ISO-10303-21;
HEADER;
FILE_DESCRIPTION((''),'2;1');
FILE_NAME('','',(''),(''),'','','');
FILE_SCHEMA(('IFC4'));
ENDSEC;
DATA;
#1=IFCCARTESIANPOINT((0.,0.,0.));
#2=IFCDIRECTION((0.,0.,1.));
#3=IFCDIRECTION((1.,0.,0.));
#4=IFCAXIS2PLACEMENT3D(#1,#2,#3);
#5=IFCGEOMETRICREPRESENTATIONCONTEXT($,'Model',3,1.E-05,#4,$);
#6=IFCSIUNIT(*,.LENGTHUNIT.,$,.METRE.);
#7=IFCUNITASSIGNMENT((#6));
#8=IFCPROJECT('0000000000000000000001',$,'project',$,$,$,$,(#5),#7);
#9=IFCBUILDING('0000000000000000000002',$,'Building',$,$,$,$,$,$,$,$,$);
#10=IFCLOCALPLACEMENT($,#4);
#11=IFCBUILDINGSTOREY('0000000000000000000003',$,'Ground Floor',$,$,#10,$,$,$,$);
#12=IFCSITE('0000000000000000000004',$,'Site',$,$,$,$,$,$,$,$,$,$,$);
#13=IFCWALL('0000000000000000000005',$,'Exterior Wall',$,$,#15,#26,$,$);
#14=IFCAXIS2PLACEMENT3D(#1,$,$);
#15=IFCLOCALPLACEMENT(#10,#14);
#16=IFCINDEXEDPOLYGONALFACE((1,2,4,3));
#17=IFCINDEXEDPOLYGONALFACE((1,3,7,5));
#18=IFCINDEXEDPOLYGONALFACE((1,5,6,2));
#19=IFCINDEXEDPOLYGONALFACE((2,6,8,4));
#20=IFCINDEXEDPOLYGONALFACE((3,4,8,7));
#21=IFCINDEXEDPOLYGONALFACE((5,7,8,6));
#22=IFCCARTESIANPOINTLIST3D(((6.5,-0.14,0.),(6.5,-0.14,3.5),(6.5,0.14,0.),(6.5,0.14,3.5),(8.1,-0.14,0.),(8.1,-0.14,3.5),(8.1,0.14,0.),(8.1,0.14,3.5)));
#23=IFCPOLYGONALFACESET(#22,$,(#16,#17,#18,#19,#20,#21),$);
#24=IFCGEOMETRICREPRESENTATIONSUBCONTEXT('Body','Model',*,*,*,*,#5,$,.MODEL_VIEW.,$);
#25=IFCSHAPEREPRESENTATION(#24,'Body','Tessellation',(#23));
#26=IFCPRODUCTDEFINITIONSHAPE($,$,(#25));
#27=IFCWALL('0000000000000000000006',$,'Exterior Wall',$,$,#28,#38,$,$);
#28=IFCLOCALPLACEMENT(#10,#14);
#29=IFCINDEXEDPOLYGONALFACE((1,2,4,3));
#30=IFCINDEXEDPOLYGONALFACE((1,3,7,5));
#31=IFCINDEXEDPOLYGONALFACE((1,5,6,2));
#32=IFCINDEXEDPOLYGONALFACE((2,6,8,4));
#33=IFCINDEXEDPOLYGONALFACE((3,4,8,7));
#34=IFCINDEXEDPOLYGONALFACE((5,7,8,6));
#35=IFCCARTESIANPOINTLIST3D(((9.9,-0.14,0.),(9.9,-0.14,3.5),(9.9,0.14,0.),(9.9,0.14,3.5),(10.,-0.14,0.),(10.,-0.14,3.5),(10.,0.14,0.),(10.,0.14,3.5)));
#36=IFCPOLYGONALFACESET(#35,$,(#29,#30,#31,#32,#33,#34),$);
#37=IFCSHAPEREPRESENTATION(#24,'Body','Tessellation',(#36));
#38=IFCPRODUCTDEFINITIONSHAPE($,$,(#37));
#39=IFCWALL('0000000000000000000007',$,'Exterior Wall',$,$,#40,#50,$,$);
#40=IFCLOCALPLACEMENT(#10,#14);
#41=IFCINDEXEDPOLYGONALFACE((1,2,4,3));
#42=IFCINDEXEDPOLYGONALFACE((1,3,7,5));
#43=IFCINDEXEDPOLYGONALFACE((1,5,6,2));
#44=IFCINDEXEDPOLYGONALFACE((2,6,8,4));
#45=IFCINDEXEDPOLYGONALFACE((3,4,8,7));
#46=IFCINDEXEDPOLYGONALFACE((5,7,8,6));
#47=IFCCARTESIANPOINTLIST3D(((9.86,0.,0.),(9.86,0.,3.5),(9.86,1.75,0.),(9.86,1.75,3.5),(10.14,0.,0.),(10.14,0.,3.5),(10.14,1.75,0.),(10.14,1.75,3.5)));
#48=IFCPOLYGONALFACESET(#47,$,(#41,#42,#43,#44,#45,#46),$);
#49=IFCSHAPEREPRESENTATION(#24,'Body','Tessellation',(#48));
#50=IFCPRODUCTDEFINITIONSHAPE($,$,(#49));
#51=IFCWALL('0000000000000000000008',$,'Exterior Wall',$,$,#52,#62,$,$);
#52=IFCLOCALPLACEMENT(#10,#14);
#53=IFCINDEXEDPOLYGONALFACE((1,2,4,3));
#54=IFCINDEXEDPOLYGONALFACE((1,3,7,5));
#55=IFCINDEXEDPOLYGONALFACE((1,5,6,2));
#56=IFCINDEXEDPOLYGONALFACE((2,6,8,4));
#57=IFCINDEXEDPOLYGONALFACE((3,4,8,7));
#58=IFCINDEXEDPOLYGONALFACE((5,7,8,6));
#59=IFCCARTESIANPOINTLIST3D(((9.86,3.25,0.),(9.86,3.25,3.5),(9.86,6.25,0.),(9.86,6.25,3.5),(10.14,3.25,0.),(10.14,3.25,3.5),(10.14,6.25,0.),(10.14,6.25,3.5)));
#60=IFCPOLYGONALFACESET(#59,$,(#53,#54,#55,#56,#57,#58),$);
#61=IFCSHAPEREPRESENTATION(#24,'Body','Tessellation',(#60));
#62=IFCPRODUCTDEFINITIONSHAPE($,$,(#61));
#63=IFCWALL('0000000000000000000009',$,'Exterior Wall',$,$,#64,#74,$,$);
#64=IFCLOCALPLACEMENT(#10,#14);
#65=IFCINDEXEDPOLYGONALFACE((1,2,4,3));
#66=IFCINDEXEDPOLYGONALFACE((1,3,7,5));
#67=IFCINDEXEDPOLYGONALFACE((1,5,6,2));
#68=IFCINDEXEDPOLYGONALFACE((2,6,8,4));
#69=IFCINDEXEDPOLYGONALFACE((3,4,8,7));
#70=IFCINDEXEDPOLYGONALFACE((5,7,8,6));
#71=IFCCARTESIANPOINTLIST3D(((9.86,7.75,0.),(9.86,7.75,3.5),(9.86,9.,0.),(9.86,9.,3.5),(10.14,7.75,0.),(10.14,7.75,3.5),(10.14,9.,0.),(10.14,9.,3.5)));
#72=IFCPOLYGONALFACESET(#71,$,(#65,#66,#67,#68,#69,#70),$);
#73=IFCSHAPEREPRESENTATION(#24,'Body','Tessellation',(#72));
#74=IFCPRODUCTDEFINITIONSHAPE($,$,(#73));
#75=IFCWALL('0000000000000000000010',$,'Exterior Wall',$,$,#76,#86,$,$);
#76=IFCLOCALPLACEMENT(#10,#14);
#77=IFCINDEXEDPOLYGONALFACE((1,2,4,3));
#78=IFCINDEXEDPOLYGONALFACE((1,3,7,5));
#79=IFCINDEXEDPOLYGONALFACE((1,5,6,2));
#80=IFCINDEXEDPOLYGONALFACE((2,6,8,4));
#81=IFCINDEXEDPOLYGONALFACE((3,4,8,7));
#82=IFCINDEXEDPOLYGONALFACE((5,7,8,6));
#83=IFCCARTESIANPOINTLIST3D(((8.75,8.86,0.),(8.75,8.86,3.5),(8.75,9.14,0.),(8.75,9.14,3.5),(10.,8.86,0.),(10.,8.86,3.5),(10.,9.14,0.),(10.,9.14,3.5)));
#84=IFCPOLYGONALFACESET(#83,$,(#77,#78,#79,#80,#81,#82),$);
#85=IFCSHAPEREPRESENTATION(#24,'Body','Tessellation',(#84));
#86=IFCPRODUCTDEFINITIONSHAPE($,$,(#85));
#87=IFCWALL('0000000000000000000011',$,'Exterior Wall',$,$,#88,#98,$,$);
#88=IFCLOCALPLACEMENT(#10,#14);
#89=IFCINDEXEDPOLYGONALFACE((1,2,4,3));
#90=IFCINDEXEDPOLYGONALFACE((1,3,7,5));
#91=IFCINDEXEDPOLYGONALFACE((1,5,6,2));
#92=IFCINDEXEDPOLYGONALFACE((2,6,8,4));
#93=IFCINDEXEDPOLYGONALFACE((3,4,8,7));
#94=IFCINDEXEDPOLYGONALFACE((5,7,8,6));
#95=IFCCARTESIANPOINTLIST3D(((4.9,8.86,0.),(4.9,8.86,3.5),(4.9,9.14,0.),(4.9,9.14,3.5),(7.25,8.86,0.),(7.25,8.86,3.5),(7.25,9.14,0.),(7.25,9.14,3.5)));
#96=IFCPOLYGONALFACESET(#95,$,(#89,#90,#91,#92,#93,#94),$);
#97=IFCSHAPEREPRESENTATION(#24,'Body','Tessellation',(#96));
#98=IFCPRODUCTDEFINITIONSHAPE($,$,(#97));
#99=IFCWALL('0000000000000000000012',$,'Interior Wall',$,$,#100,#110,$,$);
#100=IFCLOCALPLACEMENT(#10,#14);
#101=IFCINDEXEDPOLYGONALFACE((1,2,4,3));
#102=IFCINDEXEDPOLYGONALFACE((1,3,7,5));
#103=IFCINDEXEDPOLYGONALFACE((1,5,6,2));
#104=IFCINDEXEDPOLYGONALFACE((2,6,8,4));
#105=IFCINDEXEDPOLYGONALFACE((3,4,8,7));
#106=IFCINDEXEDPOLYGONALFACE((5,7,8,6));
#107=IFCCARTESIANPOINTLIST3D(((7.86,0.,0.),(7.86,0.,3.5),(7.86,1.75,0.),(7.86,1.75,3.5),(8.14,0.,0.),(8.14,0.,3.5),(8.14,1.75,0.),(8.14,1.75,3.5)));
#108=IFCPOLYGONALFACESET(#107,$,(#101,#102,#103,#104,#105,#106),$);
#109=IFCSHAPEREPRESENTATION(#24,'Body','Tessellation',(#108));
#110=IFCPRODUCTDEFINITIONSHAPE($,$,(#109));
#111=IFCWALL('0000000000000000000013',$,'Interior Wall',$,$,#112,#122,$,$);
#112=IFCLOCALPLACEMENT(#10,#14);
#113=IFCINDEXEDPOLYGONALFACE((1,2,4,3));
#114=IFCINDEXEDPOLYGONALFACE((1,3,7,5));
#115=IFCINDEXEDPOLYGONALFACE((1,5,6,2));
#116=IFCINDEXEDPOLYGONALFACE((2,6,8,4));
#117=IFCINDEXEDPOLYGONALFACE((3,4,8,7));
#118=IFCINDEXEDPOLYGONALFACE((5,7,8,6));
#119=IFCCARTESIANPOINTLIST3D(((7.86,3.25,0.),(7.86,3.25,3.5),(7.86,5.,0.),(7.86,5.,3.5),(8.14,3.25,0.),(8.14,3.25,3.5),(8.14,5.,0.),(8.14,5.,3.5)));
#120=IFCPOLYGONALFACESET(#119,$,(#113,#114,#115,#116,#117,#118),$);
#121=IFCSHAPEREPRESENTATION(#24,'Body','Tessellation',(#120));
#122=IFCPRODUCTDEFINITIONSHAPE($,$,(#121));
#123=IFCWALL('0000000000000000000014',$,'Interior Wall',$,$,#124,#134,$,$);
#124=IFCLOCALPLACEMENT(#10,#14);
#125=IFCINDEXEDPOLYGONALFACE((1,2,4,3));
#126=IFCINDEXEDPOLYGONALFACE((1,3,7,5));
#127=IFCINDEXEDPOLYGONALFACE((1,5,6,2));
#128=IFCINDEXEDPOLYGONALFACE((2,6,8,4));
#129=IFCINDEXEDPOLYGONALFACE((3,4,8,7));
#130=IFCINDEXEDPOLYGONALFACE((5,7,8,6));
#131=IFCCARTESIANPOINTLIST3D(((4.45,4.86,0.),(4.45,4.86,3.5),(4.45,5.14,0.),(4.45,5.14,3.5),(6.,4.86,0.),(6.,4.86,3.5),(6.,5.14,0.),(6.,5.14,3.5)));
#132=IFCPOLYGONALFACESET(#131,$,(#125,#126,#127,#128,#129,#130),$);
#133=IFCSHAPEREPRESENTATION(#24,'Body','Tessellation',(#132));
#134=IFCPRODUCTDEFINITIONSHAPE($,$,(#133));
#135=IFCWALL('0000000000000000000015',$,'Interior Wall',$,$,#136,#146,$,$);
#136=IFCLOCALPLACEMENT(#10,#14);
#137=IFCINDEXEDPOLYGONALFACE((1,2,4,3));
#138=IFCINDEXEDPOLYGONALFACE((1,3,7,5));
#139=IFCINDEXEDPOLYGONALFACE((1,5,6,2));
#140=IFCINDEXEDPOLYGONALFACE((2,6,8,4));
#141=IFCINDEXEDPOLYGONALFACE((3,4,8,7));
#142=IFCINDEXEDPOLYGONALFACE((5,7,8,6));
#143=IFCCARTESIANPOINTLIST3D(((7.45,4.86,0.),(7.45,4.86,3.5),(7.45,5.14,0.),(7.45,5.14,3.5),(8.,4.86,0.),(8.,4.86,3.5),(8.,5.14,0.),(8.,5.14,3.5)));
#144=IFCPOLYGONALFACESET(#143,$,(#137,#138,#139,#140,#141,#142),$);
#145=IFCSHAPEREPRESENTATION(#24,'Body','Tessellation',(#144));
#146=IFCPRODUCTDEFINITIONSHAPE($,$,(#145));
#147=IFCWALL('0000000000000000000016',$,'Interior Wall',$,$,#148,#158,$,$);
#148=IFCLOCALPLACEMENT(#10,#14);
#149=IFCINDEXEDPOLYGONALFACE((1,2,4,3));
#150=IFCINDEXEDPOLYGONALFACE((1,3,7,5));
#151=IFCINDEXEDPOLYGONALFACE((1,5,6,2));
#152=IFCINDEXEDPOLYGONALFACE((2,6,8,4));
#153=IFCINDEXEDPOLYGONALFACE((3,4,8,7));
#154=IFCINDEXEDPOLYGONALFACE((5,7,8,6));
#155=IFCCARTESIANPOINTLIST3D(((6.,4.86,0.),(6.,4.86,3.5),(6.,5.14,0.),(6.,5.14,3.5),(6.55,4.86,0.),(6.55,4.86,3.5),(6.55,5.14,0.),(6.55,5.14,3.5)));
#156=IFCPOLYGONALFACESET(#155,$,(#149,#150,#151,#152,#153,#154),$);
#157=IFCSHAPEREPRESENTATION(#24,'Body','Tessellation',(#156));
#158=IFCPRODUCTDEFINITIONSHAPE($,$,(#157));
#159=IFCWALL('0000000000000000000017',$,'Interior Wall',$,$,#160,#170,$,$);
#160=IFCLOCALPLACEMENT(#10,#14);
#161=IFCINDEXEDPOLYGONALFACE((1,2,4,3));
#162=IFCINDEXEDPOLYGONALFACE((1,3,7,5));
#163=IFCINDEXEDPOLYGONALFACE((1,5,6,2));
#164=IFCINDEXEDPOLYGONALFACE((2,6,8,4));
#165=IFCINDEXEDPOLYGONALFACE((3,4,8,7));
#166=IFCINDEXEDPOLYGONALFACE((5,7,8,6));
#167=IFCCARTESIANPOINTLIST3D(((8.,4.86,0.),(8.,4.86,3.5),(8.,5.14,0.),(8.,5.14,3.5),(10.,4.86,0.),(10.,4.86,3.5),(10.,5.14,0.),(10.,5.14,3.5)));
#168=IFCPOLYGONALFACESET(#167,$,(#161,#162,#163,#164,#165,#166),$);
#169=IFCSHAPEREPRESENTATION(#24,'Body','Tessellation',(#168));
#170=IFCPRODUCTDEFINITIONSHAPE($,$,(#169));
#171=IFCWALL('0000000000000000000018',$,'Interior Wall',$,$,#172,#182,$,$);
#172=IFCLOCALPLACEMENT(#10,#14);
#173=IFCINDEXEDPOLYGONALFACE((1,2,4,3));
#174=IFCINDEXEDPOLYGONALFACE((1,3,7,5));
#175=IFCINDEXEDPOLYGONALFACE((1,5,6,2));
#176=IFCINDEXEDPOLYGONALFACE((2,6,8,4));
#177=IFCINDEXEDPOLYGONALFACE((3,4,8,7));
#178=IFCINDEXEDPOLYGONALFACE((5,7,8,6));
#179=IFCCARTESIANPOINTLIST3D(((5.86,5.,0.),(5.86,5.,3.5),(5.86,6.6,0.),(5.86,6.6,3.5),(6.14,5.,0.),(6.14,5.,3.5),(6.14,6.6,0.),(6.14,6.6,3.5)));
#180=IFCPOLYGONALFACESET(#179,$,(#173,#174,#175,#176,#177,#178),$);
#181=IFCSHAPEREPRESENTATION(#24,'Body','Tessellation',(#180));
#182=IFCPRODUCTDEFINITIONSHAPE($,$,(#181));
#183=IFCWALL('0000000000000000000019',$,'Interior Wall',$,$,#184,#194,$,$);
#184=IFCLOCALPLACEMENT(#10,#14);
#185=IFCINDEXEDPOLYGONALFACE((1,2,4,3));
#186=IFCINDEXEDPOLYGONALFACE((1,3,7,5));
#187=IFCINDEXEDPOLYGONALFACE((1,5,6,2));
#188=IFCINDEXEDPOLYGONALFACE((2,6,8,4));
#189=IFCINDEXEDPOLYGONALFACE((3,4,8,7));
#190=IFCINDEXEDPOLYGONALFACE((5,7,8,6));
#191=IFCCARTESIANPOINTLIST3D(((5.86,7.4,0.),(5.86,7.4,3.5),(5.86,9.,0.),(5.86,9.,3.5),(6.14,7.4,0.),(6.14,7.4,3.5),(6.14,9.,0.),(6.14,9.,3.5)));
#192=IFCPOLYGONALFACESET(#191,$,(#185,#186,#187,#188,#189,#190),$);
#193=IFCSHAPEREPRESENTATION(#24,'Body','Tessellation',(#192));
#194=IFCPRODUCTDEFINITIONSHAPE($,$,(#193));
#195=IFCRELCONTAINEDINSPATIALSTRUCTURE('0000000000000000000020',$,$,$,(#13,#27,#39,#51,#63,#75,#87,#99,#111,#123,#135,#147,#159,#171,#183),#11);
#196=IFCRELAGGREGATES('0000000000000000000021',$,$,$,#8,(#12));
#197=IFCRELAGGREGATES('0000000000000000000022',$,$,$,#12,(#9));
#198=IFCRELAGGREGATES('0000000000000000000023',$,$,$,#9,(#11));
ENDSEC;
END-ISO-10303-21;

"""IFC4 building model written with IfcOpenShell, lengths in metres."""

from ifc_helpers import new_model, si_unit, frame, origin_with_axes, place, context, subcontext, project, spatial, indexed_curve, outline, extrude, element, save


model = new_model("IFC4")

# Units and contexts
model_context = context("Model", 3, precision=1e-05, world=origin_with_axes())
body_context = subcontext(model_context, "Body", "Model", "MODEL_VIEW")
ifc_project = project(units=[si_unit("LENGTHUNIT", "METRE")], contexts=[model_context])

# Site, building, storey
site = spatial("IfcSite", under=ifc_project, Name="Site")
building = spatial("IfcBuilding", under=site, Name="Building")
storey_placement = place(None, origin_with_axes())
storey = spatial("IfcBuildingStorey", under=building, at=storey_placement, Name="Ground Floor")

# Walls
wall_1_placement = place(storey_placement, frame((6.5, 0.0, 0.0), z_axis=(0.0, 0.0, 1.0), x_axis=(1.0, 0.0, 0.0)))
element("IfcWall", 1, at=wall_1_placement, inside=storey, Name="Exterior Wall", context=body_context, shape_type="SweptSolid", body=[
    extrude(outline(indexed_curve([(0.0, 0.0), (0.0, 0.28), (1.6, 0.28), (1.6, 0.0), (0.0, 0.0)], self_intersect=False)), frame((0.0, -0.14, 0.0), z_axis=(0.0, 0.0, 1.0), x_axis=(1.0, 0.0, 0.0)), (0.0, 0.0, 1.0), 3.5),
])
wall_2_placement = place(storey_placement, frame((9.9, 0.0, 0.0), z_axis=(0.0, 0.0, 1.0), x_axis=(1.0, 0.0, 0.0)))
element("IfcWall", 2, at=wall_2_placement, inside=storey, Name="Exterior Wall", context=body_context, shape_type="SweptSolid", body=[
    extrude(outline(indexed_curve([(0.0, 0.0), (0.0, 0.28), (0.1, 0.28), (0.1, 0.0), (0.0, 0.0)], self_intersect=False)), frame((0.0, -0.14, 0.0), z_axis=(0.0, 0.0, 1.0), x_axis=(1.0, 0.0, 0.0)), (0.0, 0.0, 1.0), 3.5),
])
wall_3_placement = place(storey_placement, frame((10.0, 0.0, 0.0), z_axis=(0.0, 0.0, 1.0), x_axis=(0.0, 1.0, 0.0)))
element("IfcWall", 3, at=wall_3_placement, inside=storey, Name="Exterior Wall", context=body_context, shape_type="SweptSolid", body=[
    extrude(outline(indexed_curve([(0.0, 0.0), (0.0, 0.28), (1.75, 0.28), (1.75, 0.0), (0.0, 0.0)], self_intersect=False)), frame((0.0, -0.14, 0.0), z_axis=(0.0, 0.0, 1.0), x_axis=(1.0, 0.0, 0.0)), (0.0, 0.0, 1.0), 3.5),
])
wall_4_placement = place(storey_placement, frame((10.0, 3.25, 0.0), z_axis=(0.0, 0.0, 1.0), x_axis=(0.0, 1.0, 0.0)))
element("IfcWall", 4, at=wall_4_placement, inside=storey, Name="Exterior Wall", context=body_context, shape_type="SweptSolid", body=[
    extrude(outline(indexed_curve([(0.0, 0.0), (0.0, 0.28), (3.0, 0.28), (3.0, 0.0), (0.0, 0.0)], self_intersect=False)), frame((0.0, -0.14, 0.0), z_axis=(0.0, 0.0, 1.0), x_axis=(1.0, 0.0, 0.0)), (0.0, 0.0, 1.0), 3.5),
])
for number, where, z_axis, x_axis, name in (
    (5, (10.0, 7.75, 0.0), (0.0, 0.0, 1.0), (0.0, 1.0, 0.0), "Exterior Wall"),
    (6, (10.0, 9.0, 0.0), (0.0, 0.0, 1.0), (-1.0, 0.0, 0.0), "Exterior Wall"),
):
    element("IfcWall", number, at=place(storey_placement, frame(where, z_axis=z_axis, x_axis=x_axis)), inside=storey, Name=name, context=body_context, shape_type="SweptSolid", body=[
        extrude(outline(indexed_curve([(0.0, 0.0), (0.0, 0.28), (1.25, 0.28), (1.25, 0.0), (0.0, 0.0)], self_intersect=False)), frame((0.0, -0.14, 0.0), z_axis=(0.0, 0.0, 1.0), x_axis=(1.0, 0.0, 0.0)), (0.0, 0.0, 1.0), 3.5),
    ])
wall_5_placement = place(storey_placement, frame((7.25, 9.0, 0.0), z_axis=(0.0, 0.0, 1.0), x_axis=(-1.0, 0.0, 0.0)))
element("IfcWall", 7, at=wall_5_placement, inside=storey, Name="Exterior Wall", context=body_context, shape_type="SweptSolid", body=[
    extrude(outline(indexed_curve([(0.0, 0.0), (0.0, 0.28), (2.35, 0.28), (2.35, 0.0), (0.0, 0.0)], self_intersect=False)), frame((0.0, -0.14, 0.0), z_axis=(0.0, 0.0, 1.0), x_axis=(1.0, 0.0, 0.0)), (0.0, 0.0, 1.0), 3.5),
])
for number, where, z_axis, x_axis, name in (
    (8, (8.0, 0.0, 0.0), (0.0, 0.0, 1.0), (0.0, 1.0, 0.0), "Interior Wall"),
    (9, (8.0, 3.25, 0.0), (0.0, 0.0, 1.0), (0.0, 1.0, 0.0), "Interior Wall"),
):
    element("IfcWall", number, at=place(storey_placement, frame(where, z_axis=z_axis, x_axis=x_axis)), inside=storey, Name=name, context=body_context, shape_type="SweptSolid", body=[
        extrude(outline(indexed_curve([(0.0, 0.0), (0.0, 0.28), (1.75, 0.28), (1.75, 0.0), (0.0, 0.0)], self_intersect=False)), frame((0.0, -0.14, 0.0), z_axis=(0.0, 0.0, 1.0), x_axis=(1.0, 0.0, 0.0)), (0.0, 0.0, 1.0), 3.5),
    ])
wall_6_placement = place(storey_placement, frame((6.0, 5.0, 0.0), z_axis=(0.0, 0.0, 1.0), x_axis=(-1.0, 0.0, 0.0)))
element("IfcWall", 10, at=wall_6_placement, inside=storey, Name="Interior Wall", context=body_context, shape_type="SweptSolid", body=[
    extrude(outline(indexed_curve([(0.0, 0.0), (0.0, 0.28), (1.55, 0.28), (1.55, 0.0), (0.0, 0.0)], self_intersect=False)), frame((0.0, -0.14, 0.0), z_axis=(0.0, 0.0, 1.0), x_axis=(1.0, 0.0, 0.0)), (0.0, 0.0, 1.0), 3.5),
])
for number, where, z_axis, x_axis, name in (
    (11, (8.0, 5.0, 0.0), (0.0, 0.0, 1.0), (-1.0, 0.0, 0.0), "Interior Wall"),
    (12, (6.55, 5.0, 0.0), (0.0, 0.0, 1.0), (-1.0, 0.0, 0.0), "Interior Wall"),
):
    element("IfcWall", number, at=place(storey_placement, frame(where, z_axis=z_axis, x_axis=x_axis)), inside=storey, Name=name, context=body_context, shape_type="SweptSolid", body=[
        extrude(outline(indexed_curve([(0.0, 0.0), (0.0, 0.28), (0.55, 0.28), (0.55, 0.0), (0.0, 0.0)], self_intersect=False)), frame((0.0, -0.14, 0.0), z_axis=(0.0, 0.0, 1.0), x_axis=(1.0, 0.0, 0.0)), (0.0, 0.0, 1.0), 3.5),
    ])
wall_7_placement = place(storey_placement, frame((10.0, 5.0, 0.0), z_axis=(0.0, 0.0, 1.0), x_axis=(-1.0, 0.0, 0.0)))
element("IfcWall", 13, at=wall_7_placement, inside=storey, Name="Interior Wall", context=body_context, shape_type="SweptSolid", body=[
    extrude(outline(indexed_curve([(0.0, 0.0), (0.0, 0.28), (2.0, 0.28), (2.0, 0.0), (0.0, 0.0)], self_intersect=False)), frame((0.0, -0.14, 0.0), z_axis=(0.0, 0.0, 1.0), x_axis=(1.0, 0.0, 0.0)), (0.0, 0.0, 1.0), 3.5),
])
for number, where, z_axis, x_axis, name in (
    (14, (6.0, 5.0, 0.0), (0.0, 0.0, 1.0), (0.0, 1.0, 0.0), "Interior Wall"),
    (15, (6.0, 7.4, 0.0), (0.0, 0.0, 1.0), (0.0, 1.0, 0.0), "Interior Wall"),
):
    element("IfcWall", number, at=place(storey_placement, frame(where, z_axis=z_axis, x_axis=x_axis)), inside=storey, Name=name, context=body_context, shape_type="SweptSolid", body=[
        extrude(outline(indexed_curve([(0.0, 0.0), (0.0, 0.28), (1.6, 0.28), (1.6, 0.0), (0.0, 0.0)], self_intersect=False)), frame((0.0, -0.14, 0.0), z_axis=(0.0, 0.0, 1.0), x_axis=(1.0, 0.0, 0.0)), (0.0, 0.0, 1.0), 3.5),
    ])

save(model, "model.ifc")
